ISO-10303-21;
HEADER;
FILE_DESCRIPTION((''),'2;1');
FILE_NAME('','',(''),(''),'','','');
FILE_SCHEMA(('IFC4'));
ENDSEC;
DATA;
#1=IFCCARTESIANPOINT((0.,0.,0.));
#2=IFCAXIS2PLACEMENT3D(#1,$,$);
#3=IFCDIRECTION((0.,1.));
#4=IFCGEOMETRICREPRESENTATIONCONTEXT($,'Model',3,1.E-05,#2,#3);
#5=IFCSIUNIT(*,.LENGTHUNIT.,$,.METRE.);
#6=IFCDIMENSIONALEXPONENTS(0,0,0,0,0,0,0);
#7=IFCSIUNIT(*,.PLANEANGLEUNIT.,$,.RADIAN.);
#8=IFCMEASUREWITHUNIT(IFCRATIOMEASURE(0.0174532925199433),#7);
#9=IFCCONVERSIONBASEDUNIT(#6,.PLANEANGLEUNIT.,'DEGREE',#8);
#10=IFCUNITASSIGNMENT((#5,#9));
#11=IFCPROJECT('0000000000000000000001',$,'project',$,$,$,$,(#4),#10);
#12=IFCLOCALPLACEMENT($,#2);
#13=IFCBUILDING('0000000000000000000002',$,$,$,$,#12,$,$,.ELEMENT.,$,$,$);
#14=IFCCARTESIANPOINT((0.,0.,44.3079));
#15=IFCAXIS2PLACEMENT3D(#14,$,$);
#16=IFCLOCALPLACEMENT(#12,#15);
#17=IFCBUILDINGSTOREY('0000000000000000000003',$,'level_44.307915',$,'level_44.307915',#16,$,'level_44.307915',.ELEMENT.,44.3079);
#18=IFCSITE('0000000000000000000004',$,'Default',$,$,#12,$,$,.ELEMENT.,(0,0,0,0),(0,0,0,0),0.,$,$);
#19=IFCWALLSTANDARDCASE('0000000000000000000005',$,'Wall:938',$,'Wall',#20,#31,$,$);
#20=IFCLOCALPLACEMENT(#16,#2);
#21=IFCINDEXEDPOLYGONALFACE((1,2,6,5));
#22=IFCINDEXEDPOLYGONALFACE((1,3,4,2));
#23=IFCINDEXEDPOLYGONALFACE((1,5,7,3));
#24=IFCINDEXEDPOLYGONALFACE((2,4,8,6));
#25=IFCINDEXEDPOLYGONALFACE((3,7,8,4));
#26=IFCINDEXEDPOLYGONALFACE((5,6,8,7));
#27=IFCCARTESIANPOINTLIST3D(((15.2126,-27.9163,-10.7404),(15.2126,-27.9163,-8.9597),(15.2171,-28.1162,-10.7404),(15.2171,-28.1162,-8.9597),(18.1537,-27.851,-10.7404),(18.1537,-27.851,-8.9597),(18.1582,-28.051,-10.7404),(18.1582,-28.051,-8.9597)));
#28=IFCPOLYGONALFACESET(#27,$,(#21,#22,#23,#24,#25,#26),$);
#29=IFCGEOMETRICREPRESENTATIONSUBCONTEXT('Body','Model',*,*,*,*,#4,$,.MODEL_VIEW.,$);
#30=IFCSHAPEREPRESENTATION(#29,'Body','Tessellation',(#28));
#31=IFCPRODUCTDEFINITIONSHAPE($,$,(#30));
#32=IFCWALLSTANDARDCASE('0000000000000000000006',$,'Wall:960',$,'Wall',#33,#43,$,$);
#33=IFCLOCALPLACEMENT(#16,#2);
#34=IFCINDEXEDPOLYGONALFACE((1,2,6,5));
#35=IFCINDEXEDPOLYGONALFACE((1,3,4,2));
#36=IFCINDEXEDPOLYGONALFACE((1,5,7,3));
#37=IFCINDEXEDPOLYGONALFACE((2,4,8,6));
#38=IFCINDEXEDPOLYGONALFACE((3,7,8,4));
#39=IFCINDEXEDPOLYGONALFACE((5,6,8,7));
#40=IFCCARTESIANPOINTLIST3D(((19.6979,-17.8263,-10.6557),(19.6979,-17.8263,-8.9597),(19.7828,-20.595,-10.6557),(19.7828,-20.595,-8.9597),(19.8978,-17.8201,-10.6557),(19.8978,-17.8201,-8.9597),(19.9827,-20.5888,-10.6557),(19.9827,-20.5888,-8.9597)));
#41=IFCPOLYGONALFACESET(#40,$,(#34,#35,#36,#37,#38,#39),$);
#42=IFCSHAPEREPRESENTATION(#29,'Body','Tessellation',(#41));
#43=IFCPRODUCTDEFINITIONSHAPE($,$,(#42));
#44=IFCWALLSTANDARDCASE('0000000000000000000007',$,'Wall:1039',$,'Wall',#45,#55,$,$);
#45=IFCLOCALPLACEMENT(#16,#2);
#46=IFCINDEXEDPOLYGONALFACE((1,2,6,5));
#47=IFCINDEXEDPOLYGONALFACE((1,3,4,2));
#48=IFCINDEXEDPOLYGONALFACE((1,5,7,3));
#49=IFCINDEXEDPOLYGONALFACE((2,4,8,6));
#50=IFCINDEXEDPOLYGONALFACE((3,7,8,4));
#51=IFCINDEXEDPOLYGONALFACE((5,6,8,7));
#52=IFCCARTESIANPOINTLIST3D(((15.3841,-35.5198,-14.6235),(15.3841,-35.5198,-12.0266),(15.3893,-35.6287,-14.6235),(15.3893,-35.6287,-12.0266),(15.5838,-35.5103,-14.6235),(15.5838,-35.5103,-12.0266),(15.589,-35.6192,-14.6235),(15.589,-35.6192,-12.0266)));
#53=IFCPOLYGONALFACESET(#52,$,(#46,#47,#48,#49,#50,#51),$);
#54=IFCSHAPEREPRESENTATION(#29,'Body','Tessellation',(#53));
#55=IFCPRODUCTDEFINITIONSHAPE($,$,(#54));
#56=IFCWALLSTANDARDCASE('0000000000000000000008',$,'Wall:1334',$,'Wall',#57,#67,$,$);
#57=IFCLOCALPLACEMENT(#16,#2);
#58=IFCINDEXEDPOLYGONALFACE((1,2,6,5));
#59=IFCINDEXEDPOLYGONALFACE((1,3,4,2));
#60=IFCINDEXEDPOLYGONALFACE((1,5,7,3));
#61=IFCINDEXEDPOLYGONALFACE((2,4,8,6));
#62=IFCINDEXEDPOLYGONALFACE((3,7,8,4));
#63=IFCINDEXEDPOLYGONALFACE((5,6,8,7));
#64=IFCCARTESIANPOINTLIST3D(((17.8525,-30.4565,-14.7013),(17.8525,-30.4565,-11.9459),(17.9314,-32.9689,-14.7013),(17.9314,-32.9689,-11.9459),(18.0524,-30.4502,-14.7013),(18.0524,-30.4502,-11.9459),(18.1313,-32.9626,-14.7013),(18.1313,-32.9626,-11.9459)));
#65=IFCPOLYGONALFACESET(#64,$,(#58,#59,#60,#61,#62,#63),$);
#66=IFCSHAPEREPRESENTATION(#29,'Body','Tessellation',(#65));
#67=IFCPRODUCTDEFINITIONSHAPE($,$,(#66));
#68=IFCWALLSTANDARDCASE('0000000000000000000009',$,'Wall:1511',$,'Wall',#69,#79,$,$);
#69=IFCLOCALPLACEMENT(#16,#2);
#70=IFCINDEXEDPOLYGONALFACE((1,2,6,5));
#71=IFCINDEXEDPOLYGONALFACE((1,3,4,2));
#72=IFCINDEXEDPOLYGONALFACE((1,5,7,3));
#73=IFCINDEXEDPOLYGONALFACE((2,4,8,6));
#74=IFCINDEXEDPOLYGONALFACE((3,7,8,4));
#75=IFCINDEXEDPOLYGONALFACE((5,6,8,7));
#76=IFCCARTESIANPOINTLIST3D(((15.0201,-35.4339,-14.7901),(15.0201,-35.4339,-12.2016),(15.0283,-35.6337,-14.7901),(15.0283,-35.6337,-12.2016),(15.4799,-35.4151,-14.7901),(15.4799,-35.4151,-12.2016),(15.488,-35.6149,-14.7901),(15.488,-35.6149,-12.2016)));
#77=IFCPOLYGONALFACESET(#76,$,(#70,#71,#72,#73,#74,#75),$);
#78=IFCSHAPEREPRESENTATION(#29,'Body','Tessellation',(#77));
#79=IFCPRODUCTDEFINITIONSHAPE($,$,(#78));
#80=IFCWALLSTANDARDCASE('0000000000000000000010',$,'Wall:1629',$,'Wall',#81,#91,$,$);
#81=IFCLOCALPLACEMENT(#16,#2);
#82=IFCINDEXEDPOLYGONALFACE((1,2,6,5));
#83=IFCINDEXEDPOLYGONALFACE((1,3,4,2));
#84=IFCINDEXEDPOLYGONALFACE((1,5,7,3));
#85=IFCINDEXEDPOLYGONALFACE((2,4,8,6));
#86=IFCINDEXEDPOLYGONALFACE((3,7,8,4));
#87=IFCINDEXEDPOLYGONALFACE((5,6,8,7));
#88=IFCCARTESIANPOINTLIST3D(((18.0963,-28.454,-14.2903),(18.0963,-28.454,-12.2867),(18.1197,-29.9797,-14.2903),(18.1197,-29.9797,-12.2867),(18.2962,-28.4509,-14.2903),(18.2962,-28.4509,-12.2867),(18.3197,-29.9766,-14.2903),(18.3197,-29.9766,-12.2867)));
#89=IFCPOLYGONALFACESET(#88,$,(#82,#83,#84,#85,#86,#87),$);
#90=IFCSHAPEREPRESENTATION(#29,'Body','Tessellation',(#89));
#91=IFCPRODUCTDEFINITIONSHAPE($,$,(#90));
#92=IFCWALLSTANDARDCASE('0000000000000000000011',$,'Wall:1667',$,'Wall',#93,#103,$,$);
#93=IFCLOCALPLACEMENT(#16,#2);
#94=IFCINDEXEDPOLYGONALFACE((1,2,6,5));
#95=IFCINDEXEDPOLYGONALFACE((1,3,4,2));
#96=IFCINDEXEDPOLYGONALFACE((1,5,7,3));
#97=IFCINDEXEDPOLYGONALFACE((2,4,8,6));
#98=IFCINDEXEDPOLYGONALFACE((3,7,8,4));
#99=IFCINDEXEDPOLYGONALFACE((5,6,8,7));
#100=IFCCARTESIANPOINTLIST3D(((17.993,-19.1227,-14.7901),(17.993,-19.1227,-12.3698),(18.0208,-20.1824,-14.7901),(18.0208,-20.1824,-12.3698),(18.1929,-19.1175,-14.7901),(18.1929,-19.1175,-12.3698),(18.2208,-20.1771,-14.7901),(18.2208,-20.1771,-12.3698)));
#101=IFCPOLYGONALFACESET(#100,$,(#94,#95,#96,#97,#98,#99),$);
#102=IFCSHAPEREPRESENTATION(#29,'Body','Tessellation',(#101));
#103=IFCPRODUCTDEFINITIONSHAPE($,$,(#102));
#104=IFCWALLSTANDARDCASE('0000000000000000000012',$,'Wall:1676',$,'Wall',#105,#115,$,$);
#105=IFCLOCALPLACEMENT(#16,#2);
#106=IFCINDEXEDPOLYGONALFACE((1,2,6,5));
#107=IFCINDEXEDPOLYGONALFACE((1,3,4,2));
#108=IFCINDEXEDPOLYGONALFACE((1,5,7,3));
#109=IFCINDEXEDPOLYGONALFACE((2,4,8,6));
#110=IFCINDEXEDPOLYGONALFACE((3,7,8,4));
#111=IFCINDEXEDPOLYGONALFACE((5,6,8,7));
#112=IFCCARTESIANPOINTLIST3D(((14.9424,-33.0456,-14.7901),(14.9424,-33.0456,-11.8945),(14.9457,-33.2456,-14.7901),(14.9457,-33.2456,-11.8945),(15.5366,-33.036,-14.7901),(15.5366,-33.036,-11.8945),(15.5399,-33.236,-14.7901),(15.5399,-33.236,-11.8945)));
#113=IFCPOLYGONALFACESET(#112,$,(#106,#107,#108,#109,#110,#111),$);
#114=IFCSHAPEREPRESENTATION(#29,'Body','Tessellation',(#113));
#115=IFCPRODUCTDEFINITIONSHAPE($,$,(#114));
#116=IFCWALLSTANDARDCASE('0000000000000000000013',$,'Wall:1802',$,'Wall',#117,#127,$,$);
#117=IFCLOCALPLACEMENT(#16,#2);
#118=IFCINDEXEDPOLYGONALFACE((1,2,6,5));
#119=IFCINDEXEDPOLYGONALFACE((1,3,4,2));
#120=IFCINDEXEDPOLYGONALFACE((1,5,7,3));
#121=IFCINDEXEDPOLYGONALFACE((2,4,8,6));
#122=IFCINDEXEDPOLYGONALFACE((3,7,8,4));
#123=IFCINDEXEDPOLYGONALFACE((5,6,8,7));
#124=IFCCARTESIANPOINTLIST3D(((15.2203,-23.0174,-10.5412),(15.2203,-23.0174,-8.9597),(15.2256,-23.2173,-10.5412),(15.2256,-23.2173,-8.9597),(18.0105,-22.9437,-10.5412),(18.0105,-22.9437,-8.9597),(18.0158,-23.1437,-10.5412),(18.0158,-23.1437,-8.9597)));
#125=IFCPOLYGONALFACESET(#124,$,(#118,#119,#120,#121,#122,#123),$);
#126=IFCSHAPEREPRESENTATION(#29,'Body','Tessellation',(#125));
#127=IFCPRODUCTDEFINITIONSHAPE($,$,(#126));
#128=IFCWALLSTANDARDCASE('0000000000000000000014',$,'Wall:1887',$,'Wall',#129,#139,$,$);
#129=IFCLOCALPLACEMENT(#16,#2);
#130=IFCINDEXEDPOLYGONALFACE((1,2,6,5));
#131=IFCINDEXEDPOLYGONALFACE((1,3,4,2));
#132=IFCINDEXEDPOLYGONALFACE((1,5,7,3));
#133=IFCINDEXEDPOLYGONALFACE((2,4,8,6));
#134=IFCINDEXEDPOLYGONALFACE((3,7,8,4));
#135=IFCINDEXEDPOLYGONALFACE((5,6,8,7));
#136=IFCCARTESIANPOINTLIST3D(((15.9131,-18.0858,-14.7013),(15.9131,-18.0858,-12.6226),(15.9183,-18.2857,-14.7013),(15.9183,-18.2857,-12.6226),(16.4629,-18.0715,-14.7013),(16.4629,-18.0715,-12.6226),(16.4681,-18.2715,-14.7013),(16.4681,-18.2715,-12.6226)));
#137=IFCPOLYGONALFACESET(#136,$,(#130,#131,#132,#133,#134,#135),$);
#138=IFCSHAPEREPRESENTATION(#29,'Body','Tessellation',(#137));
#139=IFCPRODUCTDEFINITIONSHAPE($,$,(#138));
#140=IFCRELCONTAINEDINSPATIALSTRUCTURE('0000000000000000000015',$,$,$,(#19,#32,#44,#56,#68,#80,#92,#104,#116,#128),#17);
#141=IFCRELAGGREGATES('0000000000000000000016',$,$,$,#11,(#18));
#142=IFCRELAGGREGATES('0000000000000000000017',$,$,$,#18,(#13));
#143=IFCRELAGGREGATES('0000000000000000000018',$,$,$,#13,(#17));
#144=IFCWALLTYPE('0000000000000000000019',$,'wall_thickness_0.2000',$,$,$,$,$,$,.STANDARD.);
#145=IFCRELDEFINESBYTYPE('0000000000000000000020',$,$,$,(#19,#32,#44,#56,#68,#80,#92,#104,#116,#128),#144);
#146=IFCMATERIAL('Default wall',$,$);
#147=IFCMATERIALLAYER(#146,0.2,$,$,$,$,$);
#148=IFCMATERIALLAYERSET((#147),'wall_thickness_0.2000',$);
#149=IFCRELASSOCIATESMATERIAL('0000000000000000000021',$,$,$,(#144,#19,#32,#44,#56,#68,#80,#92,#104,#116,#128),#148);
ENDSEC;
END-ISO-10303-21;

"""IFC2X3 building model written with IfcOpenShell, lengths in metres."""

from ifc_helpers import new_model, entity, si_unit, converted_unit, direction, frame, origin, place, context, subcontext, project, spatial, polyline, outline, extrude, material, layer, layer_set, layer_usage, type_object, element, save


model = new_model("IFC2X3")

# Units and contexts
model_context = context("Model", 3, precision=1e-05, world=origin(), true_north=direction((0.0, 1.0)))
body_context = subcontext(model_context, "Body", "Model", "MODEL_VIEW")
ifc_project = project(units=[si_unit("LENGTHUNIT", "METRE"), converted_unit("PLANEANGLEUNIT", "DEGREE", entity("IfcRatioMeasure", 0.0174532925199433), si_unit("PLANEANGLEUNIT", "RADIAN"), dimensions=[0, 0, 0, 0, 0, 0, 0])], contexts=[model_context])

# Site, building, storey
placement_1 = place(None, origin())
site = spatial("IfcSite", under=ifc_project, at=placement_1, Name="Default", CompositionType="ELEMENT", RefLatitude=(0, 0, 0, 0), RefLongitude=(0, 0, 0, 0), RefElevation=0.0)
building = spatial("IfcBuilding", under=site, at=placement_1, CompositionType="ELEMENT")
storey_placement = place(placement_1, frame((0.0, 0.0, 44.3079)))
storey = spatial("IfcBuildingStorey", under=building, at=storey_placement, Name="level_44.307915", ObjectType="level_44.307915", LongName="level_44.307915", CompositionType="ELEMENT", Elevation=44.3079)

# Shared definitions
ifc_material_1 = material(Name="Default wall")
ifc_layer = layer(ifc_material_1, 0.2)
ifc_layer_set = layer_set([ifc_layer], Name="wall_thickness_0.2000")
ifc_layer_usage = layer_usage(ifc_layer_set, "AXIS2", "POSITIVE", -0.1)
wall_type = type_object("IfcWallType", Name="wall_thickness_0.2000", PredefinedType="STANDARD", material=ifc_layer_set)

# Walls
placement_2 = place(placement_1, frame((0.0, 0.0, 33.5675)))
wall_1_placement = place(placement_2, frame((15.2149, -28.0163, 0.0), z_axis=(0.0, 0.0, 1.0), x_axis=(0.999754, 0.022185, 0.0)))
element("IfcWallStandardCase", 1, at=wall_1_placement, inside=storey, type_object=wall_type, material=ifc_layer_usage, Name="Wall:938", ObjectType="Wall", context=body_context, shape_type="SweptSolid", body=[
    extrude(outline(polyline([(2.9418, -0.1), (2.9418, 0.1), (0.0, 0.1), (0.0, -0.1), (2.9418, -0.1)])), origin(), (0.0, 0.0, 1.0), 1.7807),
])
placement_3 = place(placement_1, frame((0.0, 0.0, 33.6522)))
wall_2_placement = place(placement_3, frame((19.8828, -20.5919, 0.0), z_axis=(0.0, 0.0, 1.0), x_axis=(-0.030639, 0.999531, 0.0)))
element("IfcWallStandardCase", 2, at=wall_2_placement, inside=storey, type_object=wall_type, material=ifc_layer_usage, Name="Wall:960", ObjectType="Wall", context=body_context, shape_type="SweptSolid", body=[
    extrude(outline(polyline([(2.77, -0.1), (2.77, 0.1), (0.0, 0.1), (0.0, -0.1), (2.77, -0.1)])), origin(), (0.0, 0.0, 1.0), 1.696),
])
placement_4 = place(placement_1, frame((0.0, 0.0, 29.6844)))
wall_3_placement = place(placement_4, frame((15.484, -35.515, 0.0), z_axis=(0.0, 0.0, 1.0), x_axis=(0.0475, -0.998871, 0.0)))
element("IfcWallStandardCase", 3, at=wall_3_placement, inside=storey, type_object=wall_type, material=ifc_layer_usage, Name="Wall:1039", ObjectType="Wall", context=body_context, shape_type="SweptSolid", body=[
    extrude(outline(polyline([(0.1091, -0.1), (0.1091, 0.1), (0.0, 0.1), (0.0, -0.1), (0.1091, -0.1)])), origin(), (0.0, 0.0, 1.0), 2.5969),
])
placement_5 = place(placement_1, frame((0.0, 0.0, 29.6066)))
wall_4_placement = place(placement_5, frame((18.0314, -32.9658, 0.0), z_axis=(0.0, 0.0, 1.0), x_axis=(-0.031426, 0.999506, 0.0)))
element("IfcWallStandardCase", 4, at=wall_4_placement, inside=storey, type_object=wall_type, material=ifc_layer_usage, Name="Wall:1334", ObjectType="Wall", context=body_context, shape_type="SweptSolid", body=[
    extrude(outline(polyline([(2.5137, -0.1), (2.5137, 0.1), (0.0, 0.1), (0.0, -0.1), (2.5137, -0.1)])), origin(), (0.0, 0.0, 1.0), 2.7554),
])
placement_6 = place(placement_1, frame((0.0, 0.0, 29.5178)))
wall_5_placement = place(placement_6, frame((15.484, -35.515, 0.0), z_axis=(0.0, 0.0, 1.0), x_axis=(-0.999168, -0.04078, 0.0)))
element("IfcWallStandardCase", 5, at=wall_5_placement, inside=storey, type_object=wall_type, material=ifc_layer_usage, Name="Wall:1511", ObjectType="Wall", context=body_context, shape_type="SweptSolid", body=[
    extrude(outline(polyline([(0.4601, -0.1), (0.4601, 0.1), (0.0, 0.1), (0.0, -0.1), (0.4601, -0.1)])), origin(), (0.0, 0.0, 1.0), 2.5885),
])
placement_7 = place(placement_1, frame((0.0, 0.0, 30.0176)))
wall_6_placement = place(placement_7, frame((18.2197, -29.9782, 0.0), z_axis=(0.0, 0.0, 1.0), x_axis=(-0.015369, 0.999882, 0.0)))
element("IfcWallStandardCase", 6, at=wall_6_placement, inside=storey, type_object=wall_type, material=ifc_layer_usage, Name="Wall:1629", ObjectType="Wall", context=body_context, shape_type="SweptSolid", body=[
    extrude(outline(polyline([(1.5259, -0.1), (1.5259, 0.1), (0.0, 0.1), (0.0, -0.1), (1.5259, -0.1)])), origin(), (0.0, 0.0, 1.0), 2.0037),
])
placement_8 = place(placement_1, frame((0.0, 0.0, 29.5178)))
wall_7_placement = place(placement_8, frame((18.0929, -19.1201, 0.0), z_axis=(0.0, 0.0, 1.0), x_axis=(0.026312, -0.999654, 0.0)))
element("IfcWallStandardCase", 7, at=wall_7_placement, inside=storey, type_object=wall_type, material=ifc_layer_usage, Name="Wall:1667", ObjectType="Wall", context=body_context, shape_type="SweptSolid", body=[
    extrude(outline(polyline([(1.06, -0.1), (1.06, 0.1), (0.0, 0.1), (0.0, -0.1), (1.06, -0.1)])), origin(), (0.0, 0.0, 1.0), 2.4204),
])
placement_9 = place(placement_1, frame((0.0, 0.0, 29.5178)))
wall_8_placement = place(placement_9, frame((15.5383, -33.136, 0.0), z_axis=(0.0, 0.0, 1.0), x_axis=(-0.999871, -0.016086, 0.0)))
element("IfcWallStandardCase", 8, at=wall_8_placement, inside=storey, type_object=wall_type, material=ifc_layer_usage, Name="Wall:1676", ObjectType="Wall", context=body_context, shape_type="SweptSolid", body=[
    extrude(outline(polyline([(0.5943, -0.1), (0.5943, 0.1), (0.0, 0.1), (0.0, -0.1), (0.5943, -0.1)])), origin(), (0.0, 0.0, 1.0), 2.8956),
])
placement_10 = place(placement_1, frame((0.0, 0.0, 33.7667)))
wall_9_placement = place(placement_10, frame((15.223, -23.1173, 0.0), z_axis=(0.0, 0.0, 1.0), x_axis=(0.999652, 0.026371, 0.0)))
element("IfcWallStandardCase", 9, at=wall_9_placement, inside=storey, type_object=wall_type, material=ifc_layer_usage, Name="Wall:1802", ObjectType="Wall", context=body_context, shape_type="SweptSolid", body=[
    extrude(outline(polyline([(2.7912, -0.1), (2.7912, 0.1), (0.0, 0.1), (0.0, -0.1), (2.7912, -0.1)])), origin(), (0.0, 0.0, 1.0), 1.5815),
])
placement_11 = place(placement_1, frame((0.0, 0.0, 29.6066)))
wall_10_placement = place(placement_11, frame((16.4655, -18.1715, 0.0), z_axis=(0.0, 0.0, 1.0), x_axis=(-0.999663, -0.025961, 0.0)))
element("IfcWallStandardCase", 10, at=wall_10_placement, inside=storey, type_object=wall_type, material=ifc_layer_usage, Name="Wall:1887", ObjectType="Wall", context=body_context, shape_type="SweptSolid", body=[
    extrude(outline(polyline([(0.55, -0.1), (0.55, 0.1), (0.0, 0.1), (0.0, -0.1), (0.55, -0.1)])), origin(), (0.0, 0.0, 1.0), 2.0786),
])

save(model, "model.ifc")
